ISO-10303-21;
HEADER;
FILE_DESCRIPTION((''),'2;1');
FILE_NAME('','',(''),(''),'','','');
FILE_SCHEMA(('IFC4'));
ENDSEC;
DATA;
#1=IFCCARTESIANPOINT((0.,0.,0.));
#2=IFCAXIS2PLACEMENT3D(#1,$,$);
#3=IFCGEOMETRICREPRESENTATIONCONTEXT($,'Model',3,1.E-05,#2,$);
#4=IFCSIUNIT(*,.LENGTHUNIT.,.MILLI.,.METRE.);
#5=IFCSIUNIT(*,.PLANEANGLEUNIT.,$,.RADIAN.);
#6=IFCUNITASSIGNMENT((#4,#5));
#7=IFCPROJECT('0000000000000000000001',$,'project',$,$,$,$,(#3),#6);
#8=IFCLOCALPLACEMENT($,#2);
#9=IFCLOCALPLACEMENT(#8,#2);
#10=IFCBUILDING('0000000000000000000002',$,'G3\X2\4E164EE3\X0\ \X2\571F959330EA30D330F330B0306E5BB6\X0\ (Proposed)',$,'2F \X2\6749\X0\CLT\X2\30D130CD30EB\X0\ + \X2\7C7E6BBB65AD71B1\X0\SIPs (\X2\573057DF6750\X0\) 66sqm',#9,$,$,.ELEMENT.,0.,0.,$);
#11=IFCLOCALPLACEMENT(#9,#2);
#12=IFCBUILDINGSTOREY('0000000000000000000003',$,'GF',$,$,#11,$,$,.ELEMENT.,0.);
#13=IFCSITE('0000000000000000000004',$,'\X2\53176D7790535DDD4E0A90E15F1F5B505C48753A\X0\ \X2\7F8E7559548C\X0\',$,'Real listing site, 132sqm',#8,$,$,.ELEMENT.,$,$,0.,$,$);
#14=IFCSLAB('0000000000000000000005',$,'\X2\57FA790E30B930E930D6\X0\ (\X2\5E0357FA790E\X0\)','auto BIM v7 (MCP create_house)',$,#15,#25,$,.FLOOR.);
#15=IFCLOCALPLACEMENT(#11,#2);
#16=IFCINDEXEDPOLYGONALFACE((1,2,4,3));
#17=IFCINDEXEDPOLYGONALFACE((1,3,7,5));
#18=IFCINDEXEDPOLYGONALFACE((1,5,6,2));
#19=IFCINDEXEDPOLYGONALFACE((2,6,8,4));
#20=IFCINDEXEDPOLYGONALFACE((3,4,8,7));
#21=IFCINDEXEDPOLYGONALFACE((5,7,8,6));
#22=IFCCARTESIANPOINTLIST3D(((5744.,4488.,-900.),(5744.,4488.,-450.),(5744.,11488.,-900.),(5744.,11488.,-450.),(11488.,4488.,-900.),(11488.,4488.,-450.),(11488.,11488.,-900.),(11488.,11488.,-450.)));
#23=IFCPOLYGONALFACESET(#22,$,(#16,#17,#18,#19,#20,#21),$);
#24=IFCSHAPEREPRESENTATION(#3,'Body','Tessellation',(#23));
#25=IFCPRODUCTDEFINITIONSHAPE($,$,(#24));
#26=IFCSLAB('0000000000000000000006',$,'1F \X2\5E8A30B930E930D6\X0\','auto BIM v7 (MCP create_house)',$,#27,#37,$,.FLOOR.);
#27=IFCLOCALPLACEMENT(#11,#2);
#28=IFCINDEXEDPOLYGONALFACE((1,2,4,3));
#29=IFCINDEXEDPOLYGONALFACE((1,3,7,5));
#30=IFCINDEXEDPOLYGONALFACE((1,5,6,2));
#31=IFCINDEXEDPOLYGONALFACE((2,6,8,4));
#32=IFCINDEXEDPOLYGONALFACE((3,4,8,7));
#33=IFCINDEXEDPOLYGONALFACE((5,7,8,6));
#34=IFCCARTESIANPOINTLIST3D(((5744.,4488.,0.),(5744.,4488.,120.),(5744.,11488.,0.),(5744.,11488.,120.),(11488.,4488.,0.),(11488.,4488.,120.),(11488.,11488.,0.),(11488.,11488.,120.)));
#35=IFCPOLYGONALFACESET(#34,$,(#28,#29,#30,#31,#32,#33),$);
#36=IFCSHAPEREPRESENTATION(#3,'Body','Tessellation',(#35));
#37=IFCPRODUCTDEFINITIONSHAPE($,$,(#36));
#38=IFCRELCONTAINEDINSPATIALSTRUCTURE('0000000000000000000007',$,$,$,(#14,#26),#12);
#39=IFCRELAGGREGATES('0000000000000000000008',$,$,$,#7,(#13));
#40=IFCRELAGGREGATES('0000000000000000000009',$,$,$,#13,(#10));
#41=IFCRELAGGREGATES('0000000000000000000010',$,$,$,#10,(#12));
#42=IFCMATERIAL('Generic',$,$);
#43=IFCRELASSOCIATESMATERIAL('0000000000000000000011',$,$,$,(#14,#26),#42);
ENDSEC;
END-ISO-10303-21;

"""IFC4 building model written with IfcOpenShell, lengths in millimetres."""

from ifc_helpers import new_model, si_unit, frame, frame_2d, origin, place, context, project, spatial, rectangle, extrude, material, element, save


model = new_model("IFC4")

# Units and contexts
model_context = context("Model", 3, precision=1e-05, world=origin())
ifc_project = project(units=[si_unit("LENGTHUNIT", "METRE", prefix="MILLI"), si_unit("PLANEANGLEUNIT", "RADIAN")], contexts=[model_context])

# Site, building, storey
site_placement = place(None, origin())
site = spatial("IfcSite", under=ifc_project, at=site_placement, Name="北海道川上郡弟子屈町 美留和", ObjectType="Real listing site, 132sqm", CompositionType="ELEMENT", RefElevation=0.0)
building_placement = place(site_placement, origin())
building = spatial("IfcBuilding", under=site, at=building_placement, Name="G3世代 土間リビングの家 (Proposed)", ObjectType="2F 杉CLTパネル + 籾殻断熱SIPs (地域材) 66sqm", CompositionType="ELEMENT", ElevationOfRefHeight=0.0, ElevationOfTerrain=0.0)
storey_placement = place(building_placement, origin())
storey = spatial("IfcBuildingStorey", under=building, at=storey_placement, Name="GF", CompositionType="ELEMENT", Elevation=0.0)

# Slabs
ifc_material = material(Name="Generic")
slab_1_placement = place(storey_placement, frame((2872.0, 2244.0, -450.0)))
element("IfcSlab", 1, at=slab_1_placement, inside=storey, material=ifc_material, Name="基礎スラブ (布基礎)", Description="auto BIM v7 (MCP create_house)", PredefinedType="FLOOR", context=model_context, shape_type="SweptSolid", body=[
    extrude(rectangle(XDim=5744.0, YDim=7000.0, at=frame_2d((2872.0, 3500.0))), frame((2872.0, 2244.0, -450.0)), (0.0, 0.0, 1.0), 450.0),
])
slab_2_placement = place(storey_placement, frame((2872.0, 2244.0, 0.0)))
element("IfcSlab", 2, at=slab_2_placement, inside=storey, material=ifc_material, Name="1F 床スラブ", Description="auto BIM v7 (MCP create_house)", PredefinedType="FLOOR", context=model_context, shape_type="SweptSolid", body=[
    extrude(rectangle(XDim=5744.0, YDim=7000.0, at=frame_2d((2872.0, 3500.0))), frame((2872.0, 2244.0, 0.0)), (0.0, 0.0, 1.0), 120.0),
])

save(model, "model.ifc")
